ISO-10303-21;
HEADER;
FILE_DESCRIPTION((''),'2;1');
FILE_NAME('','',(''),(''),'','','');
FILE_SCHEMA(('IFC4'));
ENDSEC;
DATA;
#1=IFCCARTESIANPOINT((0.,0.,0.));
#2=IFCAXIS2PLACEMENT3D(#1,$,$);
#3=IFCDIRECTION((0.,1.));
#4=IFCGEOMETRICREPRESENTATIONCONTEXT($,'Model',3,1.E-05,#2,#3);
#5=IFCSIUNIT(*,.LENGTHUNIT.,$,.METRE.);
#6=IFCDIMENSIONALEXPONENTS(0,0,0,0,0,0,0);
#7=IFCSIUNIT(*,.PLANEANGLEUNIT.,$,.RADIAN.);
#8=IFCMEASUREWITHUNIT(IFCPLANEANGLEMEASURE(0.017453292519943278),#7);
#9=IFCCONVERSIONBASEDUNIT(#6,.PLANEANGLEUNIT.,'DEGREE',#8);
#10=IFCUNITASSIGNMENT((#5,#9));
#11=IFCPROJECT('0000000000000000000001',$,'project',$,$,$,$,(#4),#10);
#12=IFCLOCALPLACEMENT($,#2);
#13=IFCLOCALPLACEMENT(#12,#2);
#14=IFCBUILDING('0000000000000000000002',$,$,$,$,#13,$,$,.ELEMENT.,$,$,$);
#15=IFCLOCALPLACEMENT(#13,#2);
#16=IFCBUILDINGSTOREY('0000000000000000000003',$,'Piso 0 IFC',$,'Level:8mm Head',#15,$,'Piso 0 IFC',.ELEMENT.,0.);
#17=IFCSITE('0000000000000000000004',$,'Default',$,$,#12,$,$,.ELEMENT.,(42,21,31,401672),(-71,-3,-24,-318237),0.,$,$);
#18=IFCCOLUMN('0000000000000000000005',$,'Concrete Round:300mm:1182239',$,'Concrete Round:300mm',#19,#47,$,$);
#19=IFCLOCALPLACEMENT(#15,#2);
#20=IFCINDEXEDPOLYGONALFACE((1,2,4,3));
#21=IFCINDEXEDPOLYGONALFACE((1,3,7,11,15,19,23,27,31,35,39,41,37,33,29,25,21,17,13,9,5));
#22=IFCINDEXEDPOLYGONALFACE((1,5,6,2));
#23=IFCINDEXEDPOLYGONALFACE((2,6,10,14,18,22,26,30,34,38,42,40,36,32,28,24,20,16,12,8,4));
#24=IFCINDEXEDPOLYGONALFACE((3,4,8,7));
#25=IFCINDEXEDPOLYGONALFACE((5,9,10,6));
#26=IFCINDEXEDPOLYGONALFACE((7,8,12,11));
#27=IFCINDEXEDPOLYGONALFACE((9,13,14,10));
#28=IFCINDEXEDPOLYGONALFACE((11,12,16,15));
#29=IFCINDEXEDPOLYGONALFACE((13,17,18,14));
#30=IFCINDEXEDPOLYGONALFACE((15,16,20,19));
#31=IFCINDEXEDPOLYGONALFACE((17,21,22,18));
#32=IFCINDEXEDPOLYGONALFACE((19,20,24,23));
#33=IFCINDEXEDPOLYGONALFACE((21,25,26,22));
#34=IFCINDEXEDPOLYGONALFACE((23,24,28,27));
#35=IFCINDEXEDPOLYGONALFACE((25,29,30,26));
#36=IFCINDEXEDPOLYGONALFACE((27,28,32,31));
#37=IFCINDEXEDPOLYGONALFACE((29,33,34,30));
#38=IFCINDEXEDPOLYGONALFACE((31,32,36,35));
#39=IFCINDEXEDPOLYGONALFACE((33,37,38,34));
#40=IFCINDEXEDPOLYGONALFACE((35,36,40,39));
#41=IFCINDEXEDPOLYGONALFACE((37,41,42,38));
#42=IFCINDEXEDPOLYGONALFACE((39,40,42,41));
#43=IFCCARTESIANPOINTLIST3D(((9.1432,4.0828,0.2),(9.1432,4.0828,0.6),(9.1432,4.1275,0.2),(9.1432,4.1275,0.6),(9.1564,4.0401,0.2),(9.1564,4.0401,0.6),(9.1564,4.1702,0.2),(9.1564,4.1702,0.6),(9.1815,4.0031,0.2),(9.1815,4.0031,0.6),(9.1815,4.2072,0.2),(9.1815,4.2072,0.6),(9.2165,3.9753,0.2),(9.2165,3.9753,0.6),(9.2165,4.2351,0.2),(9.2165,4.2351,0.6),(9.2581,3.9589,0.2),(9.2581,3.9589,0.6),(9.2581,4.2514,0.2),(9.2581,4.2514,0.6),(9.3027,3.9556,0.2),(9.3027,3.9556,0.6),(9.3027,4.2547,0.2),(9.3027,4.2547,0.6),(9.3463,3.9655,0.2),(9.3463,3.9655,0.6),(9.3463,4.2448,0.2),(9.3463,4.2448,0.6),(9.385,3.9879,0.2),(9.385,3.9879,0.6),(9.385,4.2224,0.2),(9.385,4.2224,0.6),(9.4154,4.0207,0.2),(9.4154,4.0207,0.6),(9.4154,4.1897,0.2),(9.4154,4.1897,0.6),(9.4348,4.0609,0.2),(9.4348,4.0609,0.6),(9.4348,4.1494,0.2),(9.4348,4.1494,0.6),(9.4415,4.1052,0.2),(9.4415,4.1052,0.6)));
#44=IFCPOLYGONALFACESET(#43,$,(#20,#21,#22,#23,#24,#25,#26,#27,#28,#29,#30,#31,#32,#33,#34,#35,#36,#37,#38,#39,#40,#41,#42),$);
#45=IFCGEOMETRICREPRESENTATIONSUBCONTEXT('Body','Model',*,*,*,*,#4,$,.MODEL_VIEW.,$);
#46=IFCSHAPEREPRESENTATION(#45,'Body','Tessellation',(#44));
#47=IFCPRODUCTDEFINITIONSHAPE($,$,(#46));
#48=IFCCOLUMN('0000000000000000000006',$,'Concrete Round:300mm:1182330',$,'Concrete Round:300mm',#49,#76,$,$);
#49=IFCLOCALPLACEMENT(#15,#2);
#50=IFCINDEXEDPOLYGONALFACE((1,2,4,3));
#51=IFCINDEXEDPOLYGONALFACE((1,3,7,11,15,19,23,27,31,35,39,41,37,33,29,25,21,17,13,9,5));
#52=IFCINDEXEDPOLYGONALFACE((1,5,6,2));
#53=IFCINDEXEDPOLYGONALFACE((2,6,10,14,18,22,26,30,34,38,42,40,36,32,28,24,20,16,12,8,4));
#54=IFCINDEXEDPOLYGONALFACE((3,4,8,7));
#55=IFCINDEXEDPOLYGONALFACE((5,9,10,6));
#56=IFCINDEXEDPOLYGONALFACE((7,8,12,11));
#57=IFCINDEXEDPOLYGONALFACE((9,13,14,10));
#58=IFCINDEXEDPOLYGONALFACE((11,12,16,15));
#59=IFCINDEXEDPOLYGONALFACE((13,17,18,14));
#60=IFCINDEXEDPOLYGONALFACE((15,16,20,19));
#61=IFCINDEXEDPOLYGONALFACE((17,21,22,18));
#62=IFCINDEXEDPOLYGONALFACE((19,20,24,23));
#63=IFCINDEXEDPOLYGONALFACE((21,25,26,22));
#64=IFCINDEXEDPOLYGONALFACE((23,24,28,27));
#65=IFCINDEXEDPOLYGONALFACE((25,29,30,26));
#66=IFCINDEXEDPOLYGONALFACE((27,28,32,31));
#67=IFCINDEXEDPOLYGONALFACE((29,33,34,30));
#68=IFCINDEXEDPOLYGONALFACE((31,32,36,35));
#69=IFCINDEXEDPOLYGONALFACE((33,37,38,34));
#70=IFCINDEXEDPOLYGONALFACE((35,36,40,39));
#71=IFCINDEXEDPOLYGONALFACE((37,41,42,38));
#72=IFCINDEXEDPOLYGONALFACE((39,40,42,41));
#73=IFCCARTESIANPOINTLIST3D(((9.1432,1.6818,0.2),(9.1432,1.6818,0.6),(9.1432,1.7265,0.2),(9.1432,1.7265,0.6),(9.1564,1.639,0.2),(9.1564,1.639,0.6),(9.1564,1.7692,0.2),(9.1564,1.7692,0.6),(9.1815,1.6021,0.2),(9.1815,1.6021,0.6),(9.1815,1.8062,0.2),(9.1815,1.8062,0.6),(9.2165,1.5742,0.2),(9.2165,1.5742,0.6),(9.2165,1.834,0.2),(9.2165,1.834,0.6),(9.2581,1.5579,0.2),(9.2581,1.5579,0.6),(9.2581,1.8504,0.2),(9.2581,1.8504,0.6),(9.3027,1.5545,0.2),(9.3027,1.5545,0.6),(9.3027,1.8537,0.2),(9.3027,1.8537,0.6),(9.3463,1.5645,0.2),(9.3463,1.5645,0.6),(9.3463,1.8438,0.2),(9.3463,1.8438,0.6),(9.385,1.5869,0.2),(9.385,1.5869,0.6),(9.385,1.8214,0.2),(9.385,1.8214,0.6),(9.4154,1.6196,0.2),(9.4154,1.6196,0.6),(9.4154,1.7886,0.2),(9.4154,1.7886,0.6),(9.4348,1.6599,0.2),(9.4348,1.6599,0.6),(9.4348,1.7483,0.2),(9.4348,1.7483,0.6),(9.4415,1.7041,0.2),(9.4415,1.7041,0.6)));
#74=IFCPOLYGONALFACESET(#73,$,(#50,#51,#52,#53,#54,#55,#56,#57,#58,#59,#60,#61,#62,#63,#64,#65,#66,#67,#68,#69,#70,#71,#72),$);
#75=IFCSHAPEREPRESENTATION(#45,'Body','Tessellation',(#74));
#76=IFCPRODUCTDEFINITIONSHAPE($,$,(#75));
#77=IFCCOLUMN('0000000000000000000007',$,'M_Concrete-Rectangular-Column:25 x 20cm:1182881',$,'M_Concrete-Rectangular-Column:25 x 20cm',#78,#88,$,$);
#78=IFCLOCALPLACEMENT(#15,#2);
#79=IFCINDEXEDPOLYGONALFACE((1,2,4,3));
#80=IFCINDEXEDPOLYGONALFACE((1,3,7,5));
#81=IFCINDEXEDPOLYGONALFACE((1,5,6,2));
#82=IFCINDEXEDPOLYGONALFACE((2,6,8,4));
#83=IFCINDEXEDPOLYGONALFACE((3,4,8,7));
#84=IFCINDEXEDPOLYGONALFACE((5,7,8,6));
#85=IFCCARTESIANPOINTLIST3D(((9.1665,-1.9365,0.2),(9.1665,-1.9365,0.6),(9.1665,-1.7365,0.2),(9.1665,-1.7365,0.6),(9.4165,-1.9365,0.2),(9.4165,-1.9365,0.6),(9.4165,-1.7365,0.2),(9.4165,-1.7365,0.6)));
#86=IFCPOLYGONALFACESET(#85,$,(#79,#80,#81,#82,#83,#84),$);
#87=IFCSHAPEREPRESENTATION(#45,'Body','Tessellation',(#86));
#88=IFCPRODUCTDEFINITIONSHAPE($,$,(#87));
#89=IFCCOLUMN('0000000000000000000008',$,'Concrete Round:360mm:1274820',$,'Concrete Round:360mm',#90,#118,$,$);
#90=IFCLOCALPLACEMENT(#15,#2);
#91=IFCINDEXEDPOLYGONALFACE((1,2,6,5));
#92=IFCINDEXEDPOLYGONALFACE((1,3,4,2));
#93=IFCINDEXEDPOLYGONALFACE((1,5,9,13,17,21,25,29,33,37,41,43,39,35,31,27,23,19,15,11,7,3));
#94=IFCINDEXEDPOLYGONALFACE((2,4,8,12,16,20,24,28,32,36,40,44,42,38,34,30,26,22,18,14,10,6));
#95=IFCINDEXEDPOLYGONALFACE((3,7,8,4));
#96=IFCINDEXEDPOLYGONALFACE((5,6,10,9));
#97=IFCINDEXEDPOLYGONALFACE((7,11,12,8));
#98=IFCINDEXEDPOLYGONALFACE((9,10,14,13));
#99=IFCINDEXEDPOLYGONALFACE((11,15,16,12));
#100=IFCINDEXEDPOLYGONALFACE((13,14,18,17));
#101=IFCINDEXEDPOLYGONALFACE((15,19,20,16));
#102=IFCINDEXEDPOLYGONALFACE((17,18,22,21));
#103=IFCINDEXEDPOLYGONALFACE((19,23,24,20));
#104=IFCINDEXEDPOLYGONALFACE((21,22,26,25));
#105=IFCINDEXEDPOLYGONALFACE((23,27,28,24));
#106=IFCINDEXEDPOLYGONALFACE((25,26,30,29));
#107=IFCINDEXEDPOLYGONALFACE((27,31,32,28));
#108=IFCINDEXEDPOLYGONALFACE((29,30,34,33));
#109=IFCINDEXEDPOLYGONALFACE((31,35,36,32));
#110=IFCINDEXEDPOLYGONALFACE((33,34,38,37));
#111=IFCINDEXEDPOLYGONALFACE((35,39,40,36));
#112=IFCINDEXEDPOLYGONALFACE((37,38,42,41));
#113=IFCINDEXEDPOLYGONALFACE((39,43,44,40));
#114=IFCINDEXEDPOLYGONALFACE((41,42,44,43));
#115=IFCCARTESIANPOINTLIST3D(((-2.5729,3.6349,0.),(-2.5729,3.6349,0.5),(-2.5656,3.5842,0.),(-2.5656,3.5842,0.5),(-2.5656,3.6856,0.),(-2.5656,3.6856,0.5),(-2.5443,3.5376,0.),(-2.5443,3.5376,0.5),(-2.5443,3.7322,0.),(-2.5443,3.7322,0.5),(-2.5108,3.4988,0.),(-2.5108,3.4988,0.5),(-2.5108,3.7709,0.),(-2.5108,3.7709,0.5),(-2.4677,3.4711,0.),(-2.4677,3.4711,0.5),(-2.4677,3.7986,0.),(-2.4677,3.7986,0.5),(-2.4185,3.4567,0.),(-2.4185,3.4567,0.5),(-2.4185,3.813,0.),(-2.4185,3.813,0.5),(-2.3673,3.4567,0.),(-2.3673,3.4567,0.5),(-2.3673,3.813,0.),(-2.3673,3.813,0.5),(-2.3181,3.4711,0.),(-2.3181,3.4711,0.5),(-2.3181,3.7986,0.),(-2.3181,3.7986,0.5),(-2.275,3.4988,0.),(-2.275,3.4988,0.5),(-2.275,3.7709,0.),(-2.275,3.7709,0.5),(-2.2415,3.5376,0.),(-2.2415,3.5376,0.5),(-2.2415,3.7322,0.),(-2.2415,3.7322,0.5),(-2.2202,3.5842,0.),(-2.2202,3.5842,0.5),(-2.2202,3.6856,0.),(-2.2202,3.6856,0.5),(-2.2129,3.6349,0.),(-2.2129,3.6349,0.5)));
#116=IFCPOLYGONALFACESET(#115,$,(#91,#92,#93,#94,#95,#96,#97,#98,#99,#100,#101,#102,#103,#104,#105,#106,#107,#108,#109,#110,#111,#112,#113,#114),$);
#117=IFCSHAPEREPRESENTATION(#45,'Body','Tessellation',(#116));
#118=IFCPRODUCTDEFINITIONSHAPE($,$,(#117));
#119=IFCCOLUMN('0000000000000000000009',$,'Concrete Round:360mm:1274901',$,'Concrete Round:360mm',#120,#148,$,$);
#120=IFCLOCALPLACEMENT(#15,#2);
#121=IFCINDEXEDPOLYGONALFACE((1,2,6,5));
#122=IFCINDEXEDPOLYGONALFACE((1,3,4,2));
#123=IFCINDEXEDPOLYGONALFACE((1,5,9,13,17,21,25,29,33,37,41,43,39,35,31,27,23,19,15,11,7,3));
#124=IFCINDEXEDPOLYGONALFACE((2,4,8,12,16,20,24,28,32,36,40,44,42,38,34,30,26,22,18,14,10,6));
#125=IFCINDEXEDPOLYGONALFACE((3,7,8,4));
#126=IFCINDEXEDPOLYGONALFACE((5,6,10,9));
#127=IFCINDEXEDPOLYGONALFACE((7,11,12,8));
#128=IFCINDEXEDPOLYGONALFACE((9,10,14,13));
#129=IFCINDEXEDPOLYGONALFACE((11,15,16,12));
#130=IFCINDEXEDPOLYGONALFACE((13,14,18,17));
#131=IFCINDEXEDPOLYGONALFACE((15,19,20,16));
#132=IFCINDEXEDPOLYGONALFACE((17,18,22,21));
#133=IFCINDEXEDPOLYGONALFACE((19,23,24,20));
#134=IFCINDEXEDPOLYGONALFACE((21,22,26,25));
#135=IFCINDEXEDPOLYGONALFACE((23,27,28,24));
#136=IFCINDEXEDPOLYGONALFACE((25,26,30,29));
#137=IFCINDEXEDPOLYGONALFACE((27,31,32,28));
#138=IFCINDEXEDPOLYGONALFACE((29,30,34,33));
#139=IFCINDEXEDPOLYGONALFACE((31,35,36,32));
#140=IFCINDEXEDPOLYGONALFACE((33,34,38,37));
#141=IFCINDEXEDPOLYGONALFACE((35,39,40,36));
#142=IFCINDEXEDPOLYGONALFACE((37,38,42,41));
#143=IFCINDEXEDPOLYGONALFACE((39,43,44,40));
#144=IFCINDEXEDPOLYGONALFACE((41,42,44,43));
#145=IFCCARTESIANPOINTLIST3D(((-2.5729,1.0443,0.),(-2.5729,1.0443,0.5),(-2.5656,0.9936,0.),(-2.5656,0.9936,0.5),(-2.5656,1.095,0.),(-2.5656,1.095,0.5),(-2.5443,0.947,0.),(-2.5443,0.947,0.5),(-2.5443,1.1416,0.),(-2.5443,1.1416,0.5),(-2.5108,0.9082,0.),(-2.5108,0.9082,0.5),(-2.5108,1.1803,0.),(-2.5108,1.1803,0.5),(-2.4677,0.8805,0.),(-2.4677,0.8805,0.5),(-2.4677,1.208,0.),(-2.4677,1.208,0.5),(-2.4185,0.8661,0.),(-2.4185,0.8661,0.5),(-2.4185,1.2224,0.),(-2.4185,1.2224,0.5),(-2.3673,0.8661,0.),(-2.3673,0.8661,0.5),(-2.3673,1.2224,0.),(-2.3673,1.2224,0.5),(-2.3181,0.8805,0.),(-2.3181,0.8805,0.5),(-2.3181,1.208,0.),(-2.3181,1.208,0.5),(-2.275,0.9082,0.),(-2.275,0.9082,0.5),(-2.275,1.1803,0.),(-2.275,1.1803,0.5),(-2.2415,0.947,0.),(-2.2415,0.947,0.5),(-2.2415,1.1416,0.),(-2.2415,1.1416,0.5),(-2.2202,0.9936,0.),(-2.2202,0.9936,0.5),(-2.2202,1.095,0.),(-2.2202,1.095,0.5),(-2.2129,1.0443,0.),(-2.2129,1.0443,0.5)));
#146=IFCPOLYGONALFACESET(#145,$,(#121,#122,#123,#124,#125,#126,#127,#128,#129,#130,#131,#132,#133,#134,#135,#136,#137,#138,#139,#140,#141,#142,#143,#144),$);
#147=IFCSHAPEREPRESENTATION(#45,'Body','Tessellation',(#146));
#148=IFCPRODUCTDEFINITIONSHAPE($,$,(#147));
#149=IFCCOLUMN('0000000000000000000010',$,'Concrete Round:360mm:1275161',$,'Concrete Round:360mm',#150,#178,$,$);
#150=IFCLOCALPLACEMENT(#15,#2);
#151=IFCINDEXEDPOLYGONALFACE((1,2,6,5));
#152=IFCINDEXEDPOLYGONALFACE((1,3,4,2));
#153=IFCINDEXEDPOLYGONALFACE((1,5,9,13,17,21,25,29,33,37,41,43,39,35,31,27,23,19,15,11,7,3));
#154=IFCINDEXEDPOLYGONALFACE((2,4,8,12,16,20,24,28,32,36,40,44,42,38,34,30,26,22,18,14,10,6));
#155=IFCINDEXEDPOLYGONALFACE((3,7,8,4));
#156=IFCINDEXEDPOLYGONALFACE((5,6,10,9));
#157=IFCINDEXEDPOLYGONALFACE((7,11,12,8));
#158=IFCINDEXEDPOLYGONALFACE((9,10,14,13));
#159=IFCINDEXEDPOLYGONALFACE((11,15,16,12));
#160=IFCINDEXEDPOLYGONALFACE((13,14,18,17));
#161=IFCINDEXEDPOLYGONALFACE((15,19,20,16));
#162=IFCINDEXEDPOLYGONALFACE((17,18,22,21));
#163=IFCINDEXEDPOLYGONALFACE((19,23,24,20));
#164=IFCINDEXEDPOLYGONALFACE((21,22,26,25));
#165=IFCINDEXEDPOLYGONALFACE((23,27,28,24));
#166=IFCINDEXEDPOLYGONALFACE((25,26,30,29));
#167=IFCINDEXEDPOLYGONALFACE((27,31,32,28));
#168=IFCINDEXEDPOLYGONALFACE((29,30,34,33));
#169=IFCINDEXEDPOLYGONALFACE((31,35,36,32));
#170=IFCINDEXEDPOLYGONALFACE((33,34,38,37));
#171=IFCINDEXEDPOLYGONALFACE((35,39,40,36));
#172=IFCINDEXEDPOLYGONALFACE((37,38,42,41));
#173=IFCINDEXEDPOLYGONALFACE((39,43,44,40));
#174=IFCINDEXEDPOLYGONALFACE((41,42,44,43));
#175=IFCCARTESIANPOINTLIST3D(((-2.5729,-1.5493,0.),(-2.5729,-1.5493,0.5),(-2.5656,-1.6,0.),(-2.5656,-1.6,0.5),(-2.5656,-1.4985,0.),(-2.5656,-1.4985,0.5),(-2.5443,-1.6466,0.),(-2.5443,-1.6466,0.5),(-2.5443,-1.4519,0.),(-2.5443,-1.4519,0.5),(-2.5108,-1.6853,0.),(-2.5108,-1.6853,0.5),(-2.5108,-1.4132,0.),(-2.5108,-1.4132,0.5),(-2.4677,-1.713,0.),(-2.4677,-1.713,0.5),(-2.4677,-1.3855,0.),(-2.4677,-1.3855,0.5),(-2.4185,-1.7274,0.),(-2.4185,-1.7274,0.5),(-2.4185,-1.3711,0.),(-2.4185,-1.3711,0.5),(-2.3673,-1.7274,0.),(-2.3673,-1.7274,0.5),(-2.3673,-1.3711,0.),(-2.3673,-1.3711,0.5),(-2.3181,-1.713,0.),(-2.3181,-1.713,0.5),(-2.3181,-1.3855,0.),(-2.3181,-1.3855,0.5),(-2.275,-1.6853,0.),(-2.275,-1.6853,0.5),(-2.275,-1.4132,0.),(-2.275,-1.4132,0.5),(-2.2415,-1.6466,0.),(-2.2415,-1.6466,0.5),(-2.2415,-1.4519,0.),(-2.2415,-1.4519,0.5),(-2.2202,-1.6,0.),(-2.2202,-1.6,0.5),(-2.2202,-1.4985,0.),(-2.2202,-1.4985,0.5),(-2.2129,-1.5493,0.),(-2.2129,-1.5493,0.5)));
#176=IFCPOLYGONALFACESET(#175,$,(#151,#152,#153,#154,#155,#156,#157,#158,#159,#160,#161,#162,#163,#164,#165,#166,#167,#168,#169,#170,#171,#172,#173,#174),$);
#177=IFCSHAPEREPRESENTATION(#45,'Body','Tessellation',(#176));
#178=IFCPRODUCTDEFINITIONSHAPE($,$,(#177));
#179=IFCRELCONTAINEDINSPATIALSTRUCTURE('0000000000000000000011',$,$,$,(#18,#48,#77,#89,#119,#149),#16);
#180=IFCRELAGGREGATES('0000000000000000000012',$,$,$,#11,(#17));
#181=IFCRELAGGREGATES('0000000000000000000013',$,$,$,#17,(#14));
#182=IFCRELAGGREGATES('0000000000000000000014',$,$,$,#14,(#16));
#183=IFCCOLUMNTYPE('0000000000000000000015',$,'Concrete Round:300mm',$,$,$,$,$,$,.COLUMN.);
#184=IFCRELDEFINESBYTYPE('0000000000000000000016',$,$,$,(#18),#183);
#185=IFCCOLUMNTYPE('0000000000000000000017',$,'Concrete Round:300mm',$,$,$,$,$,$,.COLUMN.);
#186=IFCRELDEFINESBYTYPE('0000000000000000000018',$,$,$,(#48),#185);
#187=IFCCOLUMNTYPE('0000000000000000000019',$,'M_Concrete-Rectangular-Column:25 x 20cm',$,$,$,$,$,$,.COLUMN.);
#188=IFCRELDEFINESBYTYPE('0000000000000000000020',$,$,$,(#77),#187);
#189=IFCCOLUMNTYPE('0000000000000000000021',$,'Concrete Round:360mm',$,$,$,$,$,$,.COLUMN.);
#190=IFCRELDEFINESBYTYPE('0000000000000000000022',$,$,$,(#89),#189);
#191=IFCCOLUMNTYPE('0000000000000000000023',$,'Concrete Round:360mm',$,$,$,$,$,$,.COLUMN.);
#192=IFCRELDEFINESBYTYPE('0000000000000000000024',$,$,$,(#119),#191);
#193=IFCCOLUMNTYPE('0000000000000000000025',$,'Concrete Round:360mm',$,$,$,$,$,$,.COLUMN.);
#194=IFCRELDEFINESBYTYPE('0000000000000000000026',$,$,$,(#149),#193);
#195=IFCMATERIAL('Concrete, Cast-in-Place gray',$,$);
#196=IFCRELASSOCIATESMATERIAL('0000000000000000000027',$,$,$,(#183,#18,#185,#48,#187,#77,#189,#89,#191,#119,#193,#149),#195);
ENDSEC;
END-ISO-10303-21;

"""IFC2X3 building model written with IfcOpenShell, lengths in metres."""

from ifc_helpers import new_model, entity, si_unit, converted_unit, direction, frame, frame_2d, origin, origin_2d_with_axis, place, context, subcontext, project, spatial, rectangle, circle, extrude, source, transform, mapped, material, type_object, type_shapes, element, save


model = new_model("IFC2X3")

# Units and contexts
model_context = context("Model", 3, precision=1e-05, world=origin(), true_north=direction((0.0, 1.0)))
body_context = subcontext(model_context, "Body", "Model", "MODEL_VIEW")
ifc_project = project(units=[si_unit("LENGTHUNIT", "METRE"), converted_unit("PLANEANGLEUNIT", "DEGREE", entity("IfcPlaneAngleMeasure", 0.017453292519943278), si_unit("PLANEANGLEUNIT", "RADIAN"), dimensions=[0, 0, 0, 0, 0, 0, 0])], contexts=[model_context])

# Site, building, storey
site_placement = place(None, origin())
site = spatial("IfcSite", under=ifc_project, at=site_placement, Name="Default", CompositionType="ELEMENT", RefLatitude=(42, 21, 31, 401672), RefLongitude=(-71, -3, -24, -318237), RefElevation=0.0)
building_placement = place(site_placement, origin())
building = spatial("IfcBuilding", under=site, at=building_placement, CompositionType="ELEMENT")
storey_placement = place(building_placement, origin())
storey = spatial("IfcBuildingStorey", under=building, at=storey_placement, Name="Piso 0 IFC", ObjectType="Level:8mm Head", LongName="Piso 0 IFC", CompositionType="ELEMENT", Elevation=0.0)

# Columns
ifc_material_1 = material(Name="Concrete, Cast-in-Place gray")
column_type_1 = type_object("IfcColumnType", Name="Concrete Round:300mm", PredefinedType="COLUMN", material=ifc_material_1)
shared_shape_1 = source(origin(), body_context, "Body", "SweptSolid", [
    extrude(circle(Radius=0.15, at=origin_2d_with_axis()), frame((9.2915, 4.1052, 0.2)), (0.0, 0.0, 1.0), 0.4),
])
type_shapes(column_type_1, [shared_shape_1])
column_1_placement = place(storey_placement, origin())
element("IfcColumn", 1, at=column_1_placement, inside=storey, type_object=column_type_1, material=ifc_material_1, Name="Concrete Round:300mm:1182239", ObjectType="Concrete Round:300mm", context=body_context, shape_type="MappedRepresentation", body=[
    mapped(shared_shape_1, transform((0.0, 0.0, 0.0), scale=1.0)),
])
column_type_2 = type_object("IfcColumnType", Name="Concrete Round:300mm", PredefinedType="COLUMN", material=ifc_material_1)
shared_shape_2 = source(origin(), body_context, "Body", "SweptSolid", [
    extrude(circle(Radius=0.15, at=frame_2d((0.0, 0.0), x_axis=(1.0, 0.0))), frame((9.2915, 1.7041, 0.2)), (0.0, 0.0, 1.0), 0.4),
])
type_shapes(column_type_2, [shared_shape_2])
column_2_placement = place(storey_placement, origin())
element("IfcColumn", 2, at=column_2_placement, inside=storey, type_object=column_type_2, material=ifc_material_1, Name="Concrete Round:300mm:1182330", ObjectType="Concrete Round:300mm", context=body_context, shape_type="MappedRepresentation", body=[
    mapped(shared_shape_2, transform((0.0, 0.0, 0.0), scale=1.0)),
])
column_type_3 = type_object("IfcColumnType", Name="M_Concrete-Rectangular-Column:25 x 20cm", PredefinedType="COLUMN", material=ifc_material_1)
shared_shape_3 = source(origin(), body_context, "Body", "SweptSolid", [
    extrude(rectangle(XDim=0.4, YDim=0.2, at=origin_2d_with_axis()), frame((9.1665, -1.8365, 0.4), z_axis=(1.0, 0.0, 0.0), x_axis=(0.0, 0.0, -1.0)), (0.0, 0.0, 1.0), 0.25),
])
type_shapes(column_type_3, [shared_shape_3])
column_3_placement = place(storey_placement, origin())
element("IfcColumn", 3, at=column_3_placement, inside=storey, type_object=column_type_3, material=ifc_material_1, Name="M_Concrete-Rectangular-Column:25 x 20cm:1182881", ObjectType="M_Concrete-Rectangular-Column:25 x 20cm", context=body_context, shape_type="MappedRepresentation", body=[
    mapped(shared_shape_3, transform((0.0, 0.0, 0.0), scale=1.0)),
])
column_type_4 = type_object("IfcColumnType", Name="Concrete Round:360mm", PredefinedType="COLUMN", material=ifc_material_1)
shared_shape_4 = source(origin(), body_context, "Body", "SweptSolid", [
    extrude(circle(Radius=0.18, at=origin_2d_with_axis()), frame((-2.3929, 3.6349, 0.0)), (0.0, 0.0, 1.0), 0.5),
])
type_shapes(column_type_4, [shared_shape_4])
column_4_placement = place(storey_placement, origin())
element("IfcColumn", 4, at=column_4_placement, inside=storey, type_object=column_type_4, material=ifc_material_1, Name="Concrete Round:360mm:1274820", ObjectType="Concrete Round:360mm", context=body_context, shape_type="MappedRepresentation", body=[
    mapped(shared_shape_4, transform((0.0, 0.0, 0.0), scale=1.0)),
])
column_type_5 = type_object("IfcColumnType", Name="Concrete Round:360mm", PredefinedType="COLUMN", material=ifc_material_1)
shared_shape_5 = source(origin(), body_context, "Body", "SweptSolid", [
    extrude(circle(Radius=0.18, at=frame_2d((0.0, 0.0), x_axis=(1.0, 0.0))), frame((-2.3929, 1.0443, 0.0)), (0.0, 0.0, 1.0), 0.5),
])
type_shapes(column_type_5, [shared_shape_5])
column_5_placement = place(storey_placement, origin())
element("IfcColumn", 5, at=column_5_placement, inside=storey, type_object=column_type_5, material=ifc_material_1, Name="Concrete Round:360mm:1274901", ObjectType="Concrete Round:360mm", context=body_context, shape_type="MappedRepresentation", body=[
    mapped(shared_shape_5, transform((0.0, 0.0, 0.0), scale=1.0)),
])
column_type_6 = type_object("IfcColumnType", Name="Concrete Round:360mm", PredefinedType="COLUMN", material=ifc_material_1)
shared_shape_6 = source(origin(), body_context, "Body", "SweptSolid", [
    extrude(circle(Radius=0.18, at=frame_2d((0.0, 0.0), x_axis=(1.0, 0.0))), frame((-2.3929, -1.5493, 0.0)), (0.0, 0.0, 1.0), 0.5),
])
type_shapes(column_type_6, [shared_shape_6])
column_6_placement = place(storey_placement, origin())
element("IfcColumn", 6, at=column_6_placement, inside=storey, type_object=column_type_6, material=ifc_material_1, Name="Concrete Round:360mm:1275161", ObjectType="Concrete Round:360mm", context=body_context, shape_type="MappedRepresentation", body=[
    mapped(shared_shape_6, transform((0.0, 0.0, 0.0), scale=1.0)),
])

save(model, "model.ifc")
